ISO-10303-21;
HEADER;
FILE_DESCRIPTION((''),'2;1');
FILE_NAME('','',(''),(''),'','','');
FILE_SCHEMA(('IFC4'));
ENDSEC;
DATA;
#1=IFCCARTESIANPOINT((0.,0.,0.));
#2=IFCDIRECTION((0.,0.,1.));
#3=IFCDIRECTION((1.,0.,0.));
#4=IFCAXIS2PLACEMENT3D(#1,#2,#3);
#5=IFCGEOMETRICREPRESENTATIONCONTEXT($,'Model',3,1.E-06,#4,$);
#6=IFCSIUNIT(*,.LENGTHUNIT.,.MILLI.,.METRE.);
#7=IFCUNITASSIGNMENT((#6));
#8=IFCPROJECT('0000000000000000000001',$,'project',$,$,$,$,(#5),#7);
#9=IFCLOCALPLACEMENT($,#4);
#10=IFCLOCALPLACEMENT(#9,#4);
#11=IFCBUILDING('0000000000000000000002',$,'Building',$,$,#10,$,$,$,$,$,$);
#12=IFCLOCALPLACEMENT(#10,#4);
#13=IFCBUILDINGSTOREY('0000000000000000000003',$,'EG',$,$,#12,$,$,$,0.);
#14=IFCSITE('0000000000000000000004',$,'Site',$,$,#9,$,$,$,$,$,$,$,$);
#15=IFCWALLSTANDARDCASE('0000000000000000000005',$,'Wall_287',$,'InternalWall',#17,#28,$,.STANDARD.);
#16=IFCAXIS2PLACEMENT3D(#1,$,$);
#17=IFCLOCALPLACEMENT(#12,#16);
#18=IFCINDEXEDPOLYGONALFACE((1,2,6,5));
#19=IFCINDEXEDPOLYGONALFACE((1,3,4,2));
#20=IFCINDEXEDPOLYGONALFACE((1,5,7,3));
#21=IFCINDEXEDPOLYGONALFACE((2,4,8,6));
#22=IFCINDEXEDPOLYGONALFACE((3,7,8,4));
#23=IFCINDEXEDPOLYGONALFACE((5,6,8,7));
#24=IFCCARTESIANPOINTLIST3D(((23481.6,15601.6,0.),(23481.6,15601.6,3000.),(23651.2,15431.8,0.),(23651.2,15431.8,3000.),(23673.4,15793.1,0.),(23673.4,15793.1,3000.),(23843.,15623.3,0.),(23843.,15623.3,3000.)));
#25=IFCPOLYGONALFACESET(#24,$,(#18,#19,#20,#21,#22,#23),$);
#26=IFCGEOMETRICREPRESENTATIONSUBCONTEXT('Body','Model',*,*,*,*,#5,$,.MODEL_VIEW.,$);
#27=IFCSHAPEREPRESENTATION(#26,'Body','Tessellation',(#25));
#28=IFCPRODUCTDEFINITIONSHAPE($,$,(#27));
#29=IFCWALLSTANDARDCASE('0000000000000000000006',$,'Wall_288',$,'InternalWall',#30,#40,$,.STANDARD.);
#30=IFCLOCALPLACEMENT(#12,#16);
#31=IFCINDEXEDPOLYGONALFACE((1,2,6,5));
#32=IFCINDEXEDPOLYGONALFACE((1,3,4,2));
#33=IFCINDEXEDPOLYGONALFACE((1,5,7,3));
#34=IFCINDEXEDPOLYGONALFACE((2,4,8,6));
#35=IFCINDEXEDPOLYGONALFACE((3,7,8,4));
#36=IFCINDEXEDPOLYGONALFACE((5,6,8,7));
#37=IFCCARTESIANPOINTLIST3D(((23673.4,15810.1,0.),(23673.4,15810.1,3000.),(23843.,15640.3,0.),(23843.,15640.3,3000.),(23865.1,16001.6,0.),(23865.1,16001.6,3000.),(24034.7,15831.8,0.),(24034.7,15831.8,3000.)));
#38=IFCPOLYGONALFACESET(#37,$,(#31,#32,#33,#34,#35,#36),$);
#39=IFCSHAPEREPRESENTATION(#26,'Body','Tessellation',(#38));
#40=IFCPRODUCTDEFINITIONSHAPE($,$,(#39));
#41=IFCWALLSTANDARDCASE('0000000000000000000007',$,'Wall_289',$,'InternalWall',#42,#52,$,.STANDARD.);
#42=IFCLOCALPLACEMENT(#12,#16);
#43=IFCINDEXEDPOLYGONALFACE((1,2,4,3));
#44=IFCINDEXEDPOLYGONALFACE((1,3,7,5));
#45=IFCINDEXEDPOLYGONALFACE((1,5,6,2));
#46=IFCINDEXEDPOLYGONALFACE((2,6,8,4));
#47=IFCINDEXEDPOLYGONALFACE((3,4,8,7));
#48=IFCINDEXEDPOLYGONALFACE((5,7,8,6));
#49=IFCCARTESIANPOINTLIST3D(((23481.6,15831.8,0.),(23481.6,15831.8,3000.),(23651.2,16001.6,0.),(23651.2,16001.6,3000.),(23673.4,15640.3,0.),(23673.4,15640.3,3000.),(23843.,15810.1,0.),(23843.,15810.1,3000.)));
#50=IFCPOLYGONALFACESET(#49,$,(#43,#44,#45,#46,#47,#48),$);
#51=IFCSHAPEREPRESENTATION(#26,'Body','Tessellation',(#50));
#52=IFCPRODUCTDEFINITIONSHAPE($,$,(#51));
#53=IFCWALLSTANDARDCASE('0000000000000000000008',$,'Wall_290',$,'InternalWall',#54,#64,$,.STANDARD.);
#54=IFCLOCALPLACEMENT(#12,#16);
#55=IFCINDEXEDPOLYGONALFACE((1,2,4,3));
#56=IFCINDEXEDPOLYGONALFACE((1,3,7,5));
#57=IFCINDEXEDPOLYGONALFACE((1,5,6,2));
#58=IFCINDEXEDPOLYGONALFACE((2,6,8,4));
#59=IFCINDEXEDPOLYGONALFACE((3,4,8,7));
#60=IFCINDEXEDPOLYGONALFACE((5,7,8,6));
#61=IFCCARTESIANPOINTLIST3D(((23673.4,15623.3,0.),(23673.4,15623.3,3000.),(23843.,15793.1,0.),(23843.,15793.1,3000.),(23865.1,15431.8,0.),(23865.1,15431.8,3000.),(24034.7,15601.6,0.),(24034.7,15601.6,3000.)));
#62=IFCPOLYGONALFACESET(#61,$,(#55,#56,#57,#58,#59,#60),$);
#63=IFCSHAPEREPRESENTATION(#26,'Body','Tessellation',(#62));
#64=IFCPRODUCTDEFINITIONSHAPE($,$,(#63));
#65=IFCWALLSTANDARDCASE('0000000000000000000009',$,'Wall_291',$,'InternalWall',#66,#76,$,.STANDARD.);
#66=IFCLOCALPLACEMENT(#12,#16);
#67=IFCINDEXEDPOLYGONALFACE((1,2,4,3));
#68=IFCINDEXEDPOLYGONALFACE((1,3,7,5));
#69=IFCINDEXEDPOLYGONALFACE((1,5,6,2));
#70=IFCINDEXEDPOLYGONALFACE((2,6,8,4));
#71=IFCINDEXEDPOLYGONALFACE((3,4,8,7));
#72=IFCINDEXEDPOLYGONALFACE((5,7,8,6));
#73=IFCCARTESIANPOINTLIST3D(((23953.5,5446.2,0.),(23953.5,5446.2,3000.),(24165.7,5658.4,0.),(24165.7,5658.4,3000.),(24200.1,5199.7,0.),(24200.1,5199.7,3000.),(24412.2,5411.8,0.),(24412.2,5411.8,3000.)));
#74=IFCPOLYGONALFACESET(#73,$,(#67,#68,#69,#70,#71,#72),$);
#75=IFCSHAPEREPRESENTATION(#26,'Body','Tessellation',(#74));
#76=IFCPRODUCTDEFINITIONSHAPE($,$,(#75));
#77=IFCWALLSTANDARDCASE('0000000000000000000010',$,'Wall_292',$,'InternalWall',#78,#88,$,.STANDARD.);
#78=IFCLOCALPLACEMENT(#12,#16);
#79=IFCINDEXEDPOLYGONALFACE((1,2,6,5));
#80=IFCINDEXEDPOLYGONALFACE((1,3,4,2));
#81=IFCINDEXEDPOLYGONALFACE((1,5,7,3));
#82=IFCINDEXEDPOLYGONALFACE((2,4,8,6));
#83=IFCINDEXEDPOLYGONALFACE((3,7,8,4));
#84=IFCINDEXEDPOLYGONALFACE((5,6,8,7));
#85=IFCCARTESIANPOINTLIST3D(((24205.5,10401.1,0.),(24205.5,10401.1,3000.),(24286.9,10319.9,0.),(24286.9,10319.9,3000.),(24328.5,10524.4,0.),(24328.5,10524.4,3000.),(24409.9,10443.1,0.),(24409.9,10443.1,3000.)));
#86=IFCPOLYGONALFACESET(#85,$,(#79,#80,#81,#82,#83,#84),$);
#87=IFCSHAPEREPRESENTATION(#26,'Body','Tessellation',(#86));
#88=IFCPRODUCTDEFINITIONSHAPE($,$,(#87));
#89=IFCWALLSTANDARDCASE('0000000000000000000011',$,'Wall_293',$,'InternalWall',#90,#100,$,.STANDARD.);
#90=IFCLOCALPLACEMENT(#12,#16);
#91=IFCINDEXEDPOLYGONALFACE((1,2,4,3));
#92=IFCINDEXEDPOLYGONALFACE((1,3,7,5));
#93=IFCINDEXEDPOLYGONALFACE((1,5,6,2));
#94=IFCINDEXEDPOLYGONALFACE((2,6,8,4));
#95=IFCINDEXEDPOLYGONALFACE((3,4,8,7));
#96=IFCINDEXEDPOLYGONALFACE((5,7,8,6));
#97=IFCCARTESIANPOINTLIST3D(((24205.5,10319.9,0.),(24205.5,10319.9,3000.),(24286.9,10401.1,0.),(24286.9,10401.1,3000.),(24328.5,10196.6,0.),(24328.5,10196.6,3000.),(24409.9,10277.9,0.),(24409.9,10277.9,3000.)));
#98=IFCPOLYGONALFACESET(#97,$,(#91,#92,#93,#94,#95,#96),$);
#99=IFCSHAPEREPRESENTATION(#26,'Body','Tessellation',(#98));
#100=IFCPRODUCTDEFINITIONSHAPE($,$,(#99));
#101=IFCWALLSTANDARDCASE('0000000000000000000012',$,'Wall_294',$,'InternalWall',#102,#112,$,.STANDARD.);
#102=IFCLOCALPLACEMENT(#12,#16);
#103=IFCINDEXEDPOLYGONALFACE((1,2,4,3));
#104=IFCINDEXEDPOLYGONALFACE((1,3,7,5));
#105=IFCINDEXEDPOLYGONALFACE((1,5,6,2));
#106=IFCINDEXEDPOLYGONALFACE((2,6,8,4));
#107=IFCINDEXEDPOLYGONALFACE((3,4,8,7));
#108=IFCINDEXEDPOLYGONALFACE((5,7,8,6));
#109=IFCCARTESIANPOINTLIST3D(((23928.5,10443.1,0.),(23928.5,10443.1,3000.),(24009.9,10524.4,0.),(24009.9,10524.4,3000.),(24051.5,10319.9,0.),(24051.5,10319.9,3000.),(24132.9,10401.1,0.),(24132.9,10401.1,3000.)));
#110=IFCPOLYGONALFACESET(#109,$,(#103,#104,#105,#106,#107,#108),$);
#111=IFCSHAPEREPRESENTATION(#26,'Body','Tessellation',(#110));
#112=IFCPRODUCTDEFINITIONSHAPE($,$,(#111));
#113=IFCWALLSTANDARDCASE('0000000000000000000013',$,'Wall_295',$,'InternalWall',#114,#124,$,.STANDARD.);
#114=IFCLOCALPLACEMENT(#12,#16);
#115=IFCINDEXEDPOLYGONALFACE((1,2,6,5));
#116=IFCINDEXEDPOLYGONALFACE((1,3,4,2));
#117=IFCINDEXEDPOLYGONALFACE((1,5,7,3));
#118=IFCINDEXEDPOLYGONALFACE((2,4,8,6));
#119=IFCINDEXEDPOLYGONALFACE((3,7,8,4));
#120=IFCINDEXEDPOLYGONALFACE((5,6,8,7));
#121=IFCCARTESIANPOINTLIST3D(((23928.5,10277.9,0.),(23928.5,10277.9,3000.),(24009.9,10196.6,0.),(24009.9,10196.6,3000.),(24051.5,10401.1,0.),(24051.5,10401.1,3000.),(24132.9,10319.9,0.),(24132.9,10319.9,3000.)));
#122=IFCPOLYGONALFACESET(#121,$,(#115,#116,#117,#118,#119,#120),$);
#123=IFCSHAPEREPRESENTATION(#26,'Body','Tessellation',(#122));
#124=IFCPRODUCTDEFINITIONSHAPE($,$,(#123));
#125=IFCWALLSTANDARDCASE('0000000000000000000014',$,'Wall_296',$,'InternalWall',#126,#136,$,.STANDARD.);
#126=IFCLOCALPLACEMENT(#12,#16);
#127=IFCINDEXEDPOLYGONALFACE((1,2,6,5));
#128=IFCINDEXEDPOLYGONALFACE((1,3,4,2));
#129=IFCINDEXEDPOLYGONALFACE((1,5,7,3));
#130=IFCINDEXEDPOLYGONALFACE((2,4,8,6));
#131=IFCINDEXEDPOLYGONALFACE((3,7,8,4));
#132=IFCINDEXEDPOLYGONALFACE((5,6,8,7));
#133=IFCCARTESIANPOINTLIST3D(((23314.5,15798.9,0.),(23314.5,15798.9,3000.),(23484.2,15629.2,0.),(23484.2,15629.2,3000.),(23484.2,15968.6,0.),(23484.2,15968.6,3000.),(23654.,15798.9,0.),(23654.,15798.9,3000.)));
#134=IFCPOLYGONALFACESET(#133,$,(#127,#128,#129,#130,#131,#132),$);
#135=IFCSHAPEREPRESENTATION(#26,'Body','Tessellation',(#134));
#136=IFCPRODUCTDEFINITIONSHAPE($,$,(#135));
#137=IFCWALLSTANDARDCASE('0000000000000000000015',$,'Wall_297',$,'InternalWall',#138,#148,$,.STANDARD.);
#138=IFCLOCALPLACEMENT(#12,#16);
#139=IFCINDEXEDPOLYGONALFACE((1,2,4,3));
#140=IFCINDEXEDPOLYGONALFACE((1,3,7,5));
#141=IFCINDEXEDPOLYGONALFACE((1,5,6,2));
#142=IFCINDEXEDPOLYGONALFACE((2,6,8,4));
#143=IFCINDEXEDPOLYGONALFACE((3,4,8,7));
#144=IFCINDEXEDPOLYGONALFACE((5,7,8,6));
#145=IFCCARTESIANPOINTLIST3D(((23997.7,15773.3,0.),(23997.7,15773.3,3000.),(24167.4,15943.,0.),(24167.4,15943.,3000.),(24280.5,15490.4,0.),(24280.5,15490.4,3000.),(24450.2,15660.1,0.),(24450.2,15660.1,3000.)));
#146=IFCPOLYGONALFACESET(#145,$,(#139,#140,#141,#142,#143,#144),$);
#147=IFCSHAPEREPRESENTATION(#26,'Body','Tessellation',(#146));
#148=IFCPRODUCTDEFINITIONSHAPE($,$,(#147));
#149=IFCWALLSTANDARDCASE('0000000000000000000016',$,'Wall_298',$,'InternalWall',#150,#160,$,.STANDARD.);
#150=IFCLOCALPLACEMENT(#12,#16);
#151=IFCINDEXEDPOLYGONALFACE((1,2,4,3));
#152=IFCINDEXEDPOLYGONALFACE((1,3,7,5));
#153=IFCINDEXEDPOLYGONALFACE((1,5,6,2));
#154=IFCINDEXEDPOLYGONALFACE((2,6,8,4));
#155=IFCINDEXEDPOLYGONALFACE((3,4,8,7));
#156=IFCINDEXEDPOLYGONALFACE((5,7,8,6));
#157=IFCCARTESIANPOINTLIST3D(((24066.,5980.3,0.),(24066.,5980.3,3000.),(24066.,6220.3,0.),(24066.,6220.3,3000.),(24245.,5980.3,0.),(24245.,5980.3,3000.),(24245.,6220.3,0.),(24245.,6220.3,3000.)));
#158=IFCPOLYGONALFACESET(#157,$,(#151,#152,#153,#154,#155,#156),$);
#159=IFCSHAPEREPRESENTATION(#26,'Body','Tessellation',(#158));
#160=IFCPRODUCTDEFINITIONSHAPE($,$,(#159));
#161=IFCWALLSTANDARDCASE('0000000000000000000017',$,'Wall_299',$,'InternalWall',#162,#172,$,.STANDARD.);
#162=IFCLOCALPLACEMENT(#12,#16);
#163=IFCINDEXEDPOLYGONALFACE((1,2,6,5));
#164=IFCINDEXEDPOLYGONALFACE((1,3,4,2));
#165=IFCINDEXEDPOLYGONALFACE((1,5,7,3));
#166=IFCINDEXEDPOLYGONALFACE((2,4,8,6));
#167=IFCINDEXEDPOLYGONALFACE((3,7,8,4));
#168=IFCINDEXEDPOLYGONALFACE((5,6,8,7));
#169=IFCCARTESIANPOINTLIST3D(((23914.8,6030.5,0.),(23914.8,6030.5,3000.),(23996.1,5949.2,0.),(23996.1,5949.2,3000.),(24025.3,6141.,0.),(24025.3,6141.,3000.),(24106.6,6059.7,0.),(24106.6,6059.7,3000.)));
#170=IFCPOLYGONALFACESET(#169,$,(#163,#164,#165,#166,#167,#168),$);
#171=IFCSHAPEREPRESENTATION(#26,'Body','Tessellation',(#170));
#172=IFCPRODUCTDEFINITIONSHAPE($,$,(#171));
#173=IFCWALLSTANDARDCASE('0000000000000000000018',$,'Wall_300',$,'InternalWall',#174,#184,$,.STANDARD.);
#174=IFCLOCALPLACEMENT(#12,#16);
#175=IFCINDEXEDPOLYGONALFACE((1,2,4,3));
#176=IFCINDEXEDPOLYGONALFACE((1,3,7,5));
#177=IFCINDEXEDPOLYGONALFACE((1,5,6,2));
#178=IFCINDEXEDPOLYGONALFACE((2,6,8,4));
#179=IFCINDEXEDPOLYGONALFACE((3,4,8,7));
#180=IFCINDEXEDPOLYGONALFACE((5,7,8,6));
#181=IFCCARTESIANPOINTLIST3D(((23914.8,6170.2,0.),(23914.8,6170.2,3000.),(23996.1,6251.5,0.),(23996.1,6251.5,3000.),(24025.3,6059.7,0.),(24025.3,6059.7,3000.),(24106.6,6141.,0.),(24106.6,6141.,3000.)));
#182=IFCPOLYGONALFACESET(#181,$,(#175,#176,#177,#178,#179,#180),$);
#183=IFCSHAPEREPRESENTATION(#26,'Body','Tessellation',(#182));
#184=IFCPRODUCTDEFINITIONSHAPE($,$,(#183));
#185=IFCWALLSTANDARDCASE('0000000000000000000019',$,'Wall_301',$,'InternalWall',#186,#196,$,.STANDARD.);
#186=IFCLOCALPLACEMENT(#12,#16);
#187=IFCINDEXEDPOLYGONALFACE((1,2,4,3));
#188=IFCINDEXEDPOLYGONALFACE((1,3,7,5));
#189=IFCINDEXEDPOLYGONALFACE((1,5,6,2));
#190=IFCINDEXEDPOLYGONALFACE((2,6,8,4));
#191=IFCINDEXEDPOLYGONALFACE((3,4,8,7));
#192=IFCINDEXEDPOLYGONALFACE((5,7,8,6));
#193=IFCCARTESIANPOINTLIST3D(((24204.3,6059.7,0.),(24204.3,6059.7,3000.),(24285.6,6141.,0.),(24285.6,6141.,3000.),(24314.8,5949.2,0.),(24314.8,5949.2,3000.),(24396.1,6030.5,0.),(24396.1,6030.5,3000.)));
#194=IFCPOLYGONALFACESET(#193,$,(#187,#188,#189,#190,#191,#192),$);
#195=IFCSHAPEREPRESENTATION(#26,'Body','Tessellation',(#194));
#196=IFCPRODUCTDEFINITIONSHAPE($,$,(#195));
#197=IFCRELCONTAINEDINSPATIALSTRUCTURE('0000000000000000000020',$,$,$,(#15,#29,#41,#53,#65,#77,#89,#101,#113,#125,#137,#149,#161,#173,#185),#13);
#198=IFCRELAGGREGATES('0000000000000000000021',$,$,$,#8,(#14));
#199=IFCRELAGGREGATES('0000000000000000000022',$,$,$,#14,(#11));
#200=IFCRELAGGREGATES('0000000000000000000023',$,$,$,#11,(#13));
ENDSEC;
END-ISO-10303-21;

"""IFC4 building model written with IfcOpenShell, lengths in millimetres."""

from ifc_helpers import new_model, si_unit, frame, origin_with_axes, place, context, subcontext, project, spatial, rectangle, extrude, element, save


model = new_model("IFC4")

# Units and contexts
model_context = context("Model", 3, precision=1e-06, world=origin_with_axes())
body_context = subcontext(model_context, "Body", "Model", "MODEL_VIEW")
ifc_project = project(units=[si_unit("LENGTHUNIT", "METRE", prefix="MILLI")], contexts=[model_context])

# Site, building, storey
site_placement = place(None, origin_with_axes())
site = spatial("IfcSite", under=ifc_project, at=site_placement, Name="Site")
building_placement = place(site_placement, origin_with_axes())
building = spatial("IfcBuilding", under=site, at=building_placement, Name="Building")
storey_placement = place(building_placement, origin_with_axes())
storey = spatial("IfcBuildingStorey", under=building, at=storey_placement, Name="EG", Elevation=0.0)

# Walls
wall_1_placement = place(storey_placement, origin_with_axes())
element("IfcWallStandardCase", 1, at=wall_1_placement, inside=storey, Name="Wall_287", ObjectType="InternalWall", PredefinedType="STANDARD", context=body_context, shape_type="SweptSolid", body=[
    extrude(rectangle(XDim=271.0, YDim=240.0), frame((23662.3, 15612.4, 0.0), z_axis=(0.0, 0.0, 1.0), x_axis=(-0.707568, -0.706645, 0.0)), (0.0, 0.0, 1.0), 3000.0),
])
wall_2_placement = place(storey_placement, origin_with_axes())
element("IfcWallStandardCase", 2, at=wall_2_placement, inside=storey, Name="Wall_288", ObjectType="InternalWall", PredefinedType="STANDARD", context=body_context, shape_type="SweptSolid", body=[
    extrude(rectangle(XDim=271.0, YDim=240.0), frame((23854.1, 15820.9, 0.0), z_axis=(0.0, 0.0, 1.0), x_axis=(0.707568, 0.706645, 0.0)), (0.0, 0.0, 1.0), 3000.0),
])
wall_3_placement = place(storey_placement, origin_with_axes())
element("IfcWallStandardCase", 3, at=wall_3_placement, inside=storey, Name="Wall_289", ObjectType="InternalWall", PredefinedType="STANDARD", context=body_context, shape_type="SweptSolid", body=[
    extrude(rectangle(XDim=271.0, YDim=240.0), frame((23662.3, 15820.9, 0.0), z_axis=(0.0, 0.0, 1.0), x_axis=(-0.707568, 0.706645, 0.0)), (0.0, 0.0, 1.0), 3000.0),
])
wall_4_placement = place(storey_placement, origin_with_axes())
element("IfcWallStandardCase", 4, at=wall_4_placement, inside=storey, Name="Wall_290", ObjectType="InternalWall", PredefinedType="STANDARD", context=body_context, shape_type="SweptSolid", body=[
    extrude(rectangle(XDim=271.0, YDim=240.0), frame((23854.1, 15612.4, 0.0), z_axis=(0.0, 0.0, 1.0), x_axis=(0.707568, -0.706645, 0.0)), (0.0, 0.0, 1.0), 3000.0),
])
wall_5_placement = place(storey_placement, origin_with_axes())
element("IfcWallStandardCase", 5, at=wall_5_placement, inside=storey, Name="Wall_291", ObjectType="InternalWall", PredefinedType="STANDARD", context=body_context, shape_type="SweptSolid", body=[
    extrude(rectangle(XDim=348.7, YDim=300.0), frame((24182.9, 5429.0, 0.0), z_axis=(0.0, 0.0, 1.0), x_axis=(-0.707107, 0.707107, 0.0)), (0.0, 0.0, 1.0), 3000.0),
])
wall_6_placement = place(storey_placement, origin_with_axes())
element("IfcWallStandardCase", 6, at=wall_6_placement, inside=storey, Name="Wall_292", ObjectType="InternalWall", PredefinedType="STANDARD", context=body_context, shape_type="SweptSolid", body=[
    extrude(rectangle(XDim=174.1, YDim=115.0), frame((24307.7, 10422.1, 0.0), z_axis=(0.0, 0.0, 1.0), x_axis=(0.706389, 0.707824, 0.0)), (0.0, 0.0, 1.0), 3000.0),
])
wall_7_placement = place(storey_placement, origin_with_axes())
element("IfcWallStandardCase", 7, at=wall_7_placement, inside=storey, Name="Wall_293", ObjectType="InternalWall", PredefinedType="STANDARD", context=body_context, shape_type="SweptSolid", body=[
    extrude(rectangle(XDim=174.1, YDim=115.0), frame((24307.7, 10298.9, 0.0), z_axis=(0.0, 0.0, 1.0), x_axis=(0.706389, -0.707824, 0.0)), (0.0, 0.0, 1.0), 3000.0),
])
wall_8_placement = place(storey_placement, origin_with_axes())
element("IfcWallStandardCase", 8, at=wall_8_placement, inside=storey, Name="Wall_294", ObjectType="InternalWall", PredefinedType="STANDARD", context=body_context, shape_type="SweptSolid", body=[
    extrude(rectangle(XDim=174.1, YDim=115.0), frame((24030.7, 10422.1, 0.0), z_axis=(0.0, 0.0, 1.0), x_axis=(-0.706389, 0.707824, 0.0)), (0.0, 0.0, 1.0), 3000.0),
])
wall_9_placement = place(storey_placement, origin_with_axes())
element("IfcWallStandardCase", 9, at=wall_9_placement, inside=storey, Name="Wall_295", ObjectType="InternalWall", PredefinedType="STANDARD", context=body_context, shape_type="SweptSolid", body=[
    extrude(rectangle(XDim=174.1, YDim=115.0), frame((24030.7, 10298.9, 0.0), z_axis=(0.0, 0.0, 1.0), x_axis=(-0.706389, -0.707824, 0.0)), (0.0, 0.0, 1.0), 3000.0),
])
wall_10_placement = place(storey_placement, origin_with_axes())
element("IfcWallStandardCase", 10, at=wall_10_placement, inside=storey, Name="Wall_296", ObjectType="InternalWall", PredefinedType="STANDARD", context=body_context, shape_type="SweptSolid", body=[
    extrude(rectangle(XDim=240.0, YDim=240.0), frame((23484.2, 15798.9, 0.0), z_axis=(0.0, 0.0, 1.0), x_axis=(0.707107, 0.707107, 0.0)), (0.0, 0.0, 1.0), 3000.0),
])
wall_11_placement = place(storey_placement, origin_with_axes())
element("IfcWallStandardCase", 11, at=wall_11_placement, inside=storey, Name="Wall_297", ObjectType="InternalWall", PredefinedType="STANDARD", context=body_context, shape_type="SweptSolid", body=[
    extrude(rectangle(XDim=400.0, YDim=240.0), frame((24224.0, 15716.7, 0.0), z_axis=(0.0, 0.0, 1.0), x_axis=(-0.707107, 0.707107, 0.0)), (0.0, 0.0, 1.0), 3000.0),
])
wall_12_placement = place(storey_placement, origin_with_axes())
element("IfcWallStandardCase", 12, at=wall_12_placement, inside=storey, Name="Wall_298", ObjectType="InternalWall", PredefinedType="STANDARD", context=body_context, shape_type="SweptSolid", body=[
    extrude(rectangle(XDim=179.0, YDim=240.0), frame((24155.5, 6100.3, 0.0), z_axis=(0.0, 0.0, 1.0), x_axis=(1.0, 0.0, 0.0)), (0.0, 0.0, 1.0), 3000.0),
])
wall_13_placement = place(storey_placement, origin_with_axes())
element("IfcWallStandardCase", 13, at=wall_13_placement, inside=storey, Name="Wall_299", ObjectType="InternalWall", PredefinedType="STANDARD", context=body_context, shape_type="SweptSolid", body=[
    extrude(rectangle(XDim=156.3, YDim=115.0), frame((24010.7, 6045.1, 0.0), z_axis=(0.0, 0.0, 1.0), x_axis=(-0.707107, -0.707107, 0.0)), (0.0, 0.0, 1.0), 3000.0),
])
wall_14_placement = place(storey_placement, origin_with_axes())
element("IfcWallStandardCase", 14, at=wall_14_placement, inside=storey, Name="Wall_300", ObjectType="InternalWall", PredefinedType="STANDARD", context=body_context, shape_type="SweptSolid", body=[
    extrude(rectangle(XDim=156.3, YDim=115.0), frame((24010.7, 6155.6, 0.0), z_axis=(0.0, 0.0, 1.0), x_axis=(-0.707107, 0.707107, 0.0)), (0.0, 0.0, 1.0), 3000.0),
])
wall_15_placement = place(storey_placement, origin_with_axes())
element("IfcWallStandardCase", 15, at=wall_15_placement, inside=storey, Name="Wall_301", ObjectType="InternalWall", PredefinedType="STANDARD", context=body_context, shape_type="SweptSolid", body=[
    extrude(rectangle(XDim=156.3, YDim=115.0), frame((24300.2, 6045.1, 0.0), z_axis=(0.0, 0.0, 1.0), x_axis=(0.707107, -0.707107, 0.0)), (0.0, 0.0, 1.0), 3000.0),
])

save(model, "model.ifc")
